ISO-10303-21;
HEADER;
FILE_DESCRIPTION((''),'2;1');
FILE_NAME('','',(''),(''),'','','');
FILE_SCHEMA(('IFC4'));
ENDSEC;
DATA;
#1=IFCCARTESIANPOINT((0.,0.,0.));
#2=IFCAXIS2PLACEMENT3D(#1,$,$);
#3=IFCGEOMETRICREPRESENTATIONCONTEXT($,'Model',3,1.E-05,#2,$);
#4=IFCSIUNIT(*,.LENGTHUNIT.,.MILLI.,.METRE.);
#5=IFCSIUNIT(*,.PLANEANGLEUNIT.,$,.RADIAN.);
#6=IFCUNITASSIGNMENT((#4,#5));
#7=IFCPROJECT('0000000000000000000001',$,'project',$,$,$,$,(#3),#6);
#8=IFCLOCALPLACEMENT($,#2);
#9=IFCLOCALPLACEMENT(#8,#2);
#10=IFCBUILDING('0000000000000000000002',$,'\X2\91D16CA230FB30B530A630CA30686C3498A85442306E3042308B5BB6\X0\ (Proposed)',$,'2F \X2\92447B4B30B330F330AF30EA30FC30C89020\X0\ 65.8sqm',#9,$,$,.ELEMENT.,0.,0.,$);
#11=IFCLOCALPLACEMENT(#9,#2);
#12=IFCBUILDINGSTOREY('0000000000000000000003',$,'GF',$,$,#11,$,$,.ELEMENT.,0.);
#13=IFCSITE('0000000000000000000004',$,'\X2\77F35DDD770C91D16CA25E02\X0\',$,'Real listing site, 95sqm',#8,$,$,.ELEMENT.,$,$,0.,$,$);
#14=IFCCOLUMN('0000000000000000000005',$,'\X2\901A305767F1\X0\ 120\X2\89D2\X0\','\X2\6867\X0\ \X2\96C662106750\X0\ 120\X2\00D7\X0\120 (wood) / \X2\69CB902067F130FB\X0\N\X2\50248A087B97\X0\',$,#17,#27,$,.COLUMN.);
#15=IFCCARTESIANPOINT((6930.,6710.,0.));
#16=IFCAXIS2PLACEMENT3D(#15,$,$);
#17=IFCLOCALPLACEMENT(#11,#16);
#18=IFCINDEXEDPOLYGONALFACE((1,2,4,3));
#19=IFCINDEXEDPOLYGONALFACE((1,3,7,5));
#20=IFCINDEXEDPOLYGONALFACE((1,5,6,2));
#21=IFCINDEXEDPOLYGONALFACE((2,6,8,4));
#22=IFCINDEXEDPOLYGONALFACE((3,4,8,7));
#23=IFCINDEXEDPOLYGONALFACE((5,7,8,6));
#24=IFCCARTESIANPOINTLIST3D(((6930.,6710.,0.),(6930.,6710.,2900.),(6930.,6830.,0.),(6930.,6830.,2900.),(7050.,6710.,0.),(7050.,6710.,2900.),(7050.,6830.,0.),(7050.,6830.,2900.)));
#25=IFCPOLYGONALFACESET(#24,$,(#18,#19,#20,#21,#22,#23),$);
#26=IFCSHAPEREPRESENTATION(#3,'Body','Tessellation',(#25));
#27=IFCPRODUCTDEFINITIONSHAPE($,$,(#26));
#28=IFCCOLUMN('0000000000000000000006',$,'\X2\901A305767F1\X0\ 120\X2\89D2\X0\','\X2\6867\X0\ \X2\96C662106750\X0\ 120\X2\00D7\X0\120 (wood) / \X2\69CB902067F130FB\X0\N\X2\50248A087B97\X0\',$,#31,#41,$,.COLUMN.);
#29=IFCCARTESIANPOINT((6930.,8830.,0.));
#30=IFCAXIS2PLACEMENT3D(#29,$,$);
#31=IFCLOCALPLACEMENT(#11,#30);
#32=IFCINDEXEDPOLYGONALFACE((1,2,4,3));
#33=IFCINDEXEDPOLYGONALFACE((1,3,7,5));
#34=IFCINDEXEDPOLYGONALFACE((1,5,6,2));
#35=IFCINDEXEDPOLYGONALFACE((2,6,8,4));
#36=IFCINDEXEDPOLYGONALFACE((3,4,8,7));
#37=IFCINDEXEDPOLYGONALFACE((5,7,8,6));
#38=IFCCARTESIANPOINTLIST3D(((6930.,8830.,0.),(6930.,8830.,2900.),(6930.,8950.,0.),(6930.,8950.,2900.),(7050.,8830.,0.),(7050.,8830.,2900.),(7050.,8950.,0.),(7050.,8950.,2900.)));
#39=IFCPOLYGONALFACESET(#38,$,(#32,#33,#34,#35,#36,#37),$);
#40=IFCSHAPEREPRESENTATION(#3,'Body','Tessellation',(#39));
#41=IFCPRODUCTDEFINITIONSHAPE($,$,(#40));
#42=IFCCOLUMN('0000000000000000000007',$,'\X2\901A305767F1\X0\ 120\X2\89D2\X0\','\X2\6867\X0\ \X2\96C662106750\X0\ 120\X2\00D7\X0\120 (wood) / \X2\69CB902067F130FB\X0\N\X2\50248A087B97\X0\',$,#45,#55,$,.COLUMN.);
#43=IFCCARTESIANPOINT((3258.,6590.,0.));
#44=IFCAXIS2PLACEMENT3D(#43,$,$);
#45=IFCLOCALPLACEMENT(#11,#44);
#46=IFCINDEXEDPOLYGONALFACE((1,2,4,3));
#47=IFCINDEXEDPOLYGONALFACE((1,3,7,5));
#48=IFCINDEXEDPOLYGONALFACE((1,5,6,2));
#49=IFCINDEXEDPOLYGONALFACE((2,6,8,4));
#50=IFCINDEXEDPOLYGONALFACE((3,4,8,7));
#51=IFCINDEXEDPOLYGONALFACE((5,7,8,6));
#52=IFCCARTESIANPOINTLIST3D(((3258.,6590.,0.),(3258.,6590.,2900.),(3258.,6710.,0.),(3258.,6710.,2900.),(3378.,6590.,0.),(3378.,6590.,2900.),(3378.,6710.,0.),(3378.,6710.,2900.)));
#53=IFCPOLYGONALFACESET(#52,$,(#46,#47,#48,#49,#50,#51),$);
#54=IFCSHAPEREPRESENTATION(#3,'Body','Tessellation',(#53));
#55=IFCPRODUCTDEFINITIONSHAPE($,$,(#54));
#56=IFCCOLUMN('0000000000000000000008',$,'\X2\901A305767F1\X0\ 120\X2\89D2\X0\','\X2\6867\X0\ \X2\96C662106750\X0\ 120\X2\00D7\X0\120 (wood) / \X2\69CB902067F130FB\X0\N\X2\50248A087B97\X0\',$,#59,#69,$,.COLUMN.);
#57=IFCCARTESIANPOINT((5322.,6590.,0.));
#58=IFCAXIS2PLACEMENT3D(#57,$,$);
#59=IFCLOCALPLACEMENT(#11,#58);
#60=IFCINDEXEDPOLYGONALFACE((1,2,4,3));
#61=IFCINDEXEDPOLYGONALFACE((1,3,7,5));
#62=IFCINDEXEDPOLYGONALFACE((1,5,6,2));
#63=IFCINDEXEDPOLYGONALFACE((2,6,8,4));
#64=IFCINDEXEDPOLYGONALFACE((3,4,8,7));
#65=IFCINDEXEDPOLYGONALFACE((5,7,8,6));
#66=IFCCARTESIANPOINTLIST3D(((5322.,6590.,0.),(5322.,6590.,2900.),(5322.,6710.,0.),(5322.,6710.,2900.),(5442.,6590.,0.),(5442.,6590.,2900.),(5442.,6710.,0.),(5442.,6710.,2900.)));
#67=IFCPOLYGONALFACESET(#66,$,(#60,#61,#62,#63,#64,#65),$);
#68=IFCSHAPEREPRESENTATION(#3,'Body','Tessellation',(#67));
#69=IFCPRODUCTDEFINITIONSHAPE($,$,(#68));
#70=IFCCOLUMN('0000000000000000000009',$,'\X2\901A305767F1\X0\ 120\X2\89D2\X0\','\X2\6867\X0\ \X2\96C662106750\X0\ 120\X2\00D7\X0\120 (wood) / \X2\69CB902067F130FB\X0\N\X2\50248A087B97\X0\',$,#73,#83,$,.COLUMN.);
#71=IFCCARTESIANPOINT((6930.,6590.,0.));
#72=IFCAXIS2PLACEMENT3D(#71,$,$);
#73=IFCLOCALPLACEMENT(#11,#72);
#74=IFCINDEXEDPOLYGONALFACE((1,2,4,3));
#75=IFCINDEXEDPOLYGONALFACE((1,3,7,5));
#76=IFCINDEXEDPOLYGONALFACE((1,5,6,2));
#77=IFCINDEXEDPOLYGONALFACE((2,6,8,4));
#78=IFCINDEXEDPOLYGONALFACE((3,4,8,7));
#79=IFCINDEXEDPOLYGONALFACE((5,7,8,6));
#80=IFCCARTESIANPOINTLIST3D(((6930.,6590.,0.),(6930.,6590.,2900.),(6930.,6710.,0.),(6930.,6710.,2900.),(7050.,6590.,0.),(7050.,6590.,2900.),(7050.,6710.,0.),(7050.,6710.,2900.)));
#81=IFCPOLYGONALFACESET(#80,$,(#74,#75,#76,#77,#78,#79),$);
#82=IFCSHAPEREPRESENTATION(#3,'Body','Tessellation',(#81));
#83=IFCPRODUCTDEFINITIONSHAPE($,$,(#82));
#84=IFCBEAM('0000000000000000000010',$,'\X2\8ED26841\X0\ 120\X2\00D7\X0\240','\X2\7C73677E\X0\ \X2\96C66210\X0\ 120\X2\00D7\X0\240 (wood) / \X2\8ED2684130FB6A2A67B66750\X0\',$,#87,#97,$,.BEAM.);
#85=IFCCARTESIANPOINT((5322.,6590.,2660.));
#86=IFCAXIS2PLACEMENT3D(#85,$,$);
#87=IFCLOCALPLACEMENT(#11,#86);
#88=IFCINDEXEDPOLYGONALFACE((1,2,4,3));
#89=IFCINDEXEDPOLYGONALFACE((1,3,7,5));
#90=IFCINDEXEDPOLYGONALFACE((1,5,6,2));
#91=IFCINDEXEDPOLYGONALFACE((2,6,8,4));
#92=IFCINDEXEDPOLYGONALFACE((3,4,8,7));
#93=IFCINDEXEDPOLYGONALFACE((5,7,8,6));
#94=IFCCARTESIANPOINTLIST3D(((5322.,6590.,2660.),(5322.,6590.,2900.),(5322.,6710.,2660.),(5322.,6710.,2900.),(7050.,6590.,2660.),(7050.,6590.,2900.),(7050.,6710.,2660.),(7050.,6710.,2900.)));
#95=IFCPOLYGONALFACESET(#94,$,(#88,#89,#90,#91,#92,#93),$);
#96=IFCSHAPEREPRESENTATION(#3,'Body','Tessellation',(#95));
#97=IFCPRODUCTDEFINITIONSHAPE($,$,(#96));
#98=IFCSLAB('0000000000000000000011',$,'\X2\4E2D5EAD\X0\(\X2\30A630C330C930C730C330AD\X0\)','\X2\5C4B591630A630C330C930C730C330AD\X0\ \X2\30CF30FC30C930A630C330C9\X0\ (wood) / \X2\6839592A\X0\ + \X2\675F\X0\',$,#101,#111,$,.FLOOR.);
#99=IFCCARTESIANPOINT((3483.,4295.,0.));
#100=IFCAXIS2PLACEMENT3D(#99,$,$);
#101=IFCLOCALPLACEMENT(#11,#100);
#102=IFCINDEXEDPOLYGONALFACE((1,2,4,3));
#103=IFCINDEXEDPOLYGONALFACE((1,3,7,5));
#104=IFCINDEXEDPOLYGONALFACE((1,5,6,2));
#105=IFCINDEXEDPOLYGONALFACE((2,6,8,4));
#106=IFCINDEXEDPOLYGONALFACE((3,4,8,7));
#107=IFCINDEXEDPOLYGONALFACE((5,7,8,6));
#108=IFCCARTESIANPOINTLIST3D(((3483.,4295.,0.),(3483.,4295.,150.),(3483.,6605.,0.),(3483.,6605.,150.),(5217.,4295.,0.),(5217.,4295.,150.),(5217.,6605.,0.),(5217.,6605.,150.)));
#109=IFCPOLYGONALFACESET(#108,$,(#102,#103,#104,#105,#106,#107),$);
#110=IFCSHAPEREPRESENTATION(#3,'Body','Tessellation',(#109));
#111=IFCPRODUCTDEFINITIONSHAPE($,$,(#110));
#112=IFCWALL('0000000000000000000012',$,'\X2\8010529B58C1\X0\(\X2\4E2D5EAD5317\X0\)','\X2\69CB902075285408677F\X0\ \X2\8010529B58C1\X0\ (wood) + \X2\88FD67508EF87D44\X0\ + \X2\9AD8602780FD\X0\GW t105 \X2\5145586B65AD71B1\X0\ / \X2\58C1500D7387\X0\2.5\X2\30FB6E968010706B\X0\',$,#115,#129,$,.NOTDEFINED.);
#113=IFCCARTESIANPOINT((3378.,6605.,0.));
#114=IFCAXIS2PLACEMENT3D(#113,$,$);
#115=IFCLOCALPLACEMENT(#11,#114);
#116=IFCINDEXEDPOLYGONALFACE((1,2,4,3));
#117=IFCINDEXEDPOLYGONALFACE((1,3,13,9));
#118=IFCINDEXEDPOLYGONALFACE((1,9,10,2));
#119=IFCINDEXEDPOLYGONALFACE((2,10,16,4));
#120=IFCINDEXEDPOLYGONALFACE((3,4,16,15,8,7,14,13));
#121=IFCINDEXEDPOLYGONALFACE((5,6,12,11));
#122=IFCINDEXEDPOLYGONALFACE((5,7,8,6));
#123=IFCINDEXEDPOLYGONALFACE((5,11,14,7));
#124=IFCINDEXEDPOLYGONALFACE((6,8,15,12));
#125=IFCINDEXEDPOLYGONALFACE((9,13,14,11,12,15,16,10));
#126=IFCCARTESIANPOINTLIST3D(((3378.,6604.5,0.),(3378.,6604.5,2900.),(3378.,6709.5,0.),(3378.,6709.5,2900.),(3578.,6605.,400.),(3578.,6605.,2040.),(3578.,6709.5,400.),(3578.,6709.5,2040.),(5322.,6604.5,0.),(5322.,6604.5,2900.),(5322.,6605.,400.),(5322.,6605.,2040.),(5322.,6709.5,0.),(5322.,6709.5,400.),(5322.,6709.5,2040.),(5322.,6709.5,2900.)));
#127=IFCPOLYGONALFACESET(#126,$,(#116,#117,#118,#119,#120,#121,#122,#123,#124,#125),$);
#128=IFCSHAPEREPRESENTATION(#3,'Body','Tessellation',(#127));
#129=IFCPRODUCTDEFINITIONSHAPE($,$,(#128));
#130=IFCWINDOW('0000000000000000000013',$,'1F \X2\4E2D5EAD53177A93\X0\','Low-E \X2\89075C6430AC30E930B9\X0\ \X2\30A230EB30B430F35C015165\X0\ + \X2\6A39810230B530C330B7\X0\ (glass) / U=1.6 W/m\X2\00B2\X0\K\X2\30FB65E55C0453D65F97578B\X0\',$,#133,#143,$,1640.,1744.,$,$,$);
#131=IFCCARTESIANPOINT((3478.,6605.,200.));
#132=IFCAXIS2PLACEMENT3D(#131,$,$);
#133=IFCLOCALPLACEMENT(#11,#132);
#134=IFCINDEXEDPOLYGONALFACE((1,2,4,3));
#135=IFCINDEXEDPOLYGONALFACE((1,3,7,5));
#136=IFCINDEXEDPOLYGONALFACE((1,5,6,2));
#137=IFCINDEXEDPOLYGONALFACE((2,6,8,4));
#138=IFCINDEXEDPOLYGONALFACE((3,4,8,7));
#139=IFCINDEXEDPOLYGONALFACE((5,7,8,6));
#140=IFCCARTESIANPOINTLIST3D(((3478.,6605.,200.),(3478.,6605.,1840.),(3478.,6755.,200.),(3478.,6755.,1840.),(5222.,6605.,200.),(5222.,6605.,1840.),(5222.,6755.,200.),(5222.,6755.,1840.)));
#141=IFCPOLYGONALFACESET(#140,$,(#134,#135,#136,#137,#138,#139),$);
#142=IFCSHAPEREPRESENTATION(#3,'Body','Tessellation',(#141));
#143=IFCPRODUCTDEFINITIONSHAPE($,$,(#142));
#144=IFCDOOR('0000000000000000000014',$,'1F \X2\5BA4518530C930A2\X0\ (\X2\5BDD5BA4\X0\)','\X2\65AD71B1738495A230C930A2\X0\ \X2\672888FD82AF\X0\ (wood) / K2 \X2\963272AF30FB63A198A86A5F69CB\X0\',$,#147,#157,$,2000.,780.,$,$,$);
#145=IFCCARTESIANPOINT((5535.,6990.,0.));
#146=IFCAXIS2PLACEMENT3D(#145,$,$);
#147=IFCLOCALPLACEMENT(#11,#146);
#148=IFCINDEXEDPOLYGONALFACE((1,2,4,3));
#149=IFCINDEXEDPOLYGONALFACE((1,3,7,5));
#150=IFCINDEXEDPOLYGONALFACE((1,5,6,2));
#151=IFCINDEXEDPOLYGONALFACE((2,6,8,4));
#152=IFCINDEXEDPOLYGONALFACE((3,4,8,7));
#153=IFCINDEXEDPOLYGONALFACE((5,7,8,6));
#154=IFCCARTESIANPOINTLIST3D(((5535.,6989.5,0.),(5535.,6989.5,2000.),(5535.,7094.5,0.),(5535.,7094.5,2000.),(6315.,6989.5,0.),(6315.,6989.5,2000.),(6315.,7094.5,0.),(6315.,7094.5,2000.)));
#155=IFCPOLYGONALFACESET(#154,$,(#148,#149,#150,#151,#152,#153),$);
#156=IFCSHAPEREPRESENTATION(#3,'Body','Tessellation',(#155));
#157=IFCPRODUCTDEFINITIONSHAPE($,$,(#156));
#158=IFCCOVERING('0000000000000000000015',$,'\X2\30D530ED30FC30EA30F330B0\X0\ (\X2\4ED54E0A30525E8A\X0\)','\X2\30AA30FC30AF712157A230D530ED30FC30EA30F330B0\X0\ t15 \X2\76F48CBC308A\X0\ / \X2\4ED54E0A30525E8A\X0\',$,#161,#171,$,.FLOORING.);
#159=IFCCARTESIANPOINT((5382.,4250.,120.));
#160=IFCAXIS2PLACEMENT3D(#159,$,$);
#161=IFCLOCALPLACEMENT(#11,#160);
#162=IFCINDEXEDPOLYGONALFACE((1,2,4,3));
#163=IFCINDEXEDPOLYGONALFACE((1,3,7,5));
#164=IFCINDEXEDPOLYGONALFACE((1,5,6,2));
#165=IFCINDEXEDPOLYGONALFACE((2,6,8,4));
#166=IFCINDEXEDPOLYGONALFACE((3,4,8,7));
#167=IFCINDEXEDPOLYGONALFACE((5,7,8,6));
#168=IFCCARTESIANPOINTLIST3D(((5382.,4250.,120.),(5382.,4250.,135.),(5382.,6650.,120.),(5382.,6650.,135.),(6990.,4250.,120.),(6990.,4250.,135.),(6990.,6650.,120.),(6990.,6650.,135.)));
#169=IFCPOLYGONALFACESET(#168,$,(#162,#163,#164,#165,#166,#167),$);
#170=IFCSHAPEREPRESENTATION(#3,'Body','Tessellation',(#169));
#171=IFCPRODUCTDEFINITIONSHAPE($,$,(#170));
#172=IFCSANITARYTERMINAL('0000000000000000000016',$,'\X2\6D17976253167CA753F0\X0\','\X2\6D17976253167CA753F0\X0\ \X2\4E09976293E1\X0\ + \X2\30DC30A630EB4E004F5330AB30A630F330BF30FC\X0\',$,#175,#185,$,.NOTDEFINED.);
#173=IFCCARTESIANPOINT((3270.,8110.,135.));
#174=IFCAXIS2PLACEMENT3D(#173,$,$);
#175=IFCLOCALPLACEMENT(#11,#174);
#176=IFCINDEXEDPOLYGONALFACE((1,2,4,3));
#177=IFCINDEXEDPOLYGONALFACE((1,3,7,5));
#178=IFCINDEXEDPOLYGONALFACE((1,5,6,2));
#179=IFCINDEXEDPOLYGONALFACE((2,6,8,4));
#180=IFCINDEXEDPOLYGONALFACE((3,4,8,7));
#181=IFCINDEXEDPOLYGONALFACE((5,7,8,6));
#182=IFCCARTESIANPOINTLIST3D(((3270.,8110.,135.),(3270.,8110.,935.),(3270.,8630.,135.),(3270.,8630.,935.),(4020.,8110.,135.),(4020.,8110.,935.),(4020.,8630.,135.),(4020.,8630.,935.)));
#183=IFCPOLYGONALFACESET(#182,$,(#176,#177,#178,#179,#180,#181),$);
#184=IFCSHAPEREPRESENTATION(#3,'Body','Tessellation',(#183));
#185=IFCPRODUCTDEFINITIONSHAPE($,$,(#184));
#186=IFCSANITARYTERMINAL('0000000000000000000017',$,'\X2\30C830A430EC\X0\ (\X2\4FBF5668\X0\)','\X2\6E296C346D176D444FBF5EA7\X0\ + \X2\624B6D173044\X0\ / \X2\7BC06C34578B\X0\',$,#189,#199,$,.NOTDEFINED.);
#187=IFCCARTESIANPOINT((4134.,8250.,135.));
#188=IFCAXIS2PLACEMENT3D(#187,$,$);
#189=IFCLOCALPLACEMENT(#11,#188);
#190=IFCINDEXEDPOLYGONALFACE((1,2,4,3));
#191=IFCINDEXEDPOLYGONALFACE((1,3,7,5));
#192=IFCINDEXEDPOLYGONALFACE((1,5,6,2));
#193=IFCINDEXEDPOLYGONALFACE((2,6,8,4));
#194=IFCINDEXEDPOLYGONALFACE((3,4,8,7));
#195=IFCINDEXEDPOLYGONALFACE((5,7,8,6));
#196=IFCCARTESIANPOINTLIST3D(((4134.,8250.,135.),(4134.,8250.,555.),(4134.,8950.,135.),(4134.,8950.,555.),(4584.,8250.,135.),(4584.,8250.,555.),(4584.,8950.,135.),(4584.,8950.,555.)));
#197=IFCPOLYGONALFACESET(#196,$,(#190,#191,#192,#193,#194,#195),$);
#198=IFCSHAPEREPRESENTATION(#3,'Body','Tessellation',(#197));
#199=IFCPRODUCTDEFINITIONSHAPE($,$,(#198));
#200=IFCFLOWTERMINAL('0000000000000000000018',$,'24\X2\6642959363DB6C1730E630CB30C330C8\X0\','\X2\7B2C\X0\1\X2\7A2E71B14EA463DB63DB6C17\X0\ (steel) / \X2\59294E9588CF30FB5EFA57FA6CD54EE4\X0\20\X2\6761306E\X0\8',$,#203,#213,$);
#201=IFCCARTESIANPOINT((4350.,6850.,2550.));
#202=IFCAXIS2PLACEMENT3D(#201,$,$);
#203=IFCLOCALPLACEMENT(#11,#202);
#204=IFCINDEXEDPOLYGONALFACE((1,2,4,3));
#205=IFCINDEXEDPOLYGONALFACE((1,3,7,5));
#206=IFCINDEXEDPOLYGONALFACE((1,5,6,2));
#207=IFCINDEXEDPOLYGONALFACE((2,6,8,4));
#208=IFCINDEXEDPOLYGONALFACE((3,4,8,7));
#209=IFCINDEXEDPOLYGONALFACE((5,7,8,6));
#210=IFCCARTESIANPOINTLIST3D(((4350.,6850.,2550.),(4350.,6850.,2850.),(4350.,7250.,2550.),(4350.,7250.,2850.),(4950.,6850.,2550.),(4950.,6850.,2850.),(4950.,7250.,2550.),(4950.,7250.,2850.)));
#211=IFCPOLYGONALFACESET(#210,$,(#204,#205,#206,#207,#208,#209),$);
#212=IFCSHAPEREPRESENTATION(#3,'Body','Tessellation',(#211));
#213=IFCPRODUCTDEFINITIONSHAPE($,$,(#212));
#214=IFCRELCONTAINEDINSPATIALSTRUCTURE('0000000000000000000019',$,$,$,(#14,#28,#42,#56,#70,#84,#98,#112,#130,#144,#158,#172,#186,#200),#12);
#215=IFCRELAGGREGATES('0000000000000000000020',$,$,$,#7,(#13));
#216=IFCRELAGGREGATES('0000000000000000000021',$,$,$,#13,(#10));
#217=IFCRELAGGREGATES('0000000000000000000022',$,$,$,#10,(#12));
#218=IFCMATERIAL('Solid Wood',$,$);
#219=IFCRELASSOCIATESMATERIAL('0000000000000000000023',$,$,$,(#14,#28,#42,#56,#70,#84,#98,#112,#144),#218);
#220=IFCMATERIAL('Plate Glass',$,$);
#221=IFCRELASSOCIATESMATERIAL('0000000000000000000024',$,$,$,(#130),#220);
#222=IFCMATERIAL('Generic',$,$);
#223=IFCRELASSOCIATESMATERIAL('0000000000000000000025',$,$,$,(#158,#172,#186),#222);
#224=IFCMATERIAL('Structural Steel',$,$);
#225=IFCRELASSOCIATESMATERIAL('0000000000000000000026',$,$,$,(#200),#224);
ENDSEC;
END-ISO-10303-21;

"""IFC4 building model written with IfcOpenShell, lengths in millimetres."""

from ifc_helpers import new_model, si_unit, frame, frame_2d, origin, place, context, project, spatial, rectangle, extrude, material, element, fill, save


model = new_model("IFC4")

# Units and contexts
model_context = context("Model", 3, precision=1e-05, world=origin())
ifc_project = project(units=[si_unit("LENGTHUNIT", "METRE", prefix="MILLI"), si_unit("PLANEANGLEUNIT", "RADIAN")], contexts=[model_context])

# Site, building, storey
site_placement = place(None, origin())
site = spatial("IfcSite", under=ifc_project, at=site_placement, Name="石川県金沢市", ObjectType="Real listing site, 95sqm", CompositionType="ELEMENT", RefElevation=0.0)
building_placement = place(site_placement, origin())
building = spatial("IfcBuilding", under=site, at=building_placement, Name="金沢・サウナと水風呂のある家 (Proposed)", ObjectType="2F 鉄筋コンクリート造 65.8sqm", CompositionType="ELEMENT", ElevationOfRefHeight=0.0, ElevationOfTerrain=0.0)
storey_placement = place(building_placement, origin())
storey = spatial("IfcBuildingStorey", under=building, at=storey_placement, Name="GF", CompositionType="ELEMENT", Elevation=0.0)

# Columns
ifc_material_1 = material(Name="Solid Wood")
column_1_placement = place(storey_placement, frame((6930.0, 6710.0, 0.0)))
element("IfcColumn", 1, at=column_1_placement, inside=storey, material=ifc_material_1, Name="通し柱 120角", Description="桧 集成材 120×120 (wood) / 構造柱・N値計算", PredefinedType="COLUMN", context=model_context, shape_type="SweptSolid", body=[
    extrude(rectangle(XDim=120.0, YDim=120.0, at=frame_2d((60.0, 60.0))), frame((6930.0, 6710.0, 0.0)), (0.0, 0.0, 1.0), 2900.0),
])
column_2_placement = place(storey_placement, frame((6930.0, 8830.0, 0.0)))
element("IfcColumn", 2, at=column_2_placement, inside=storey, material=ifc_material_1, Name="通し柱 120角", Description="桧 集成材 120×120 (wood) / 構造柱・N値計算", PredefinedType="COLUMN", context=model_context, shape_type="SweptSolid", body=[
    extrude(rectangle(XDim=120.0, YDim=120.0, at=frame_2d((60.0, 60.0))), frame((6930.0, 8830.0, 0.0)), (0.0, 0.0, 1.0), 2900.0),
])
column_3_placement = place(storey_placement, frame((3258.0, 6590.0, 0.0)))
element("IfcColumn", 3, at=column_3_placement, inside=storey, material=ifc_material_1, Name="通し柱 120角", Description="桧 集成材 120×120 (wood) / 構造柱・N値計算", PredefinedType="COLUMN", context=model_context, shape_type="SweptSolid", body=[
    extrude(rectangle(XDim=120.0, YDim=120.0, at=frame_2d((60.0, 60.0))), frame((3258.0, 6590.0, 0.0)), (0.0, 0.0, 1.0), 2900.0),
])
column_4_placement = place(storey_placement, frame((5322.0, 6590.0, 0.0)))
element("IfcColumn", 4, at=column_4_placement, inside=storey, material=ifc_material_1, Name="通し柱 120角", Description="桧 集成材 120×120 (wood) / 構造柱・N値計算", PredefinedType="COLUMN", context=model_context, shape_type="SweptSolid", body=[
    extrude(rectangle(XDim=120.0, YDim=120.0, at=frame_2d((60.0, 60.0))), frame((5322.0, 6590.0, 0.0)), (0.0, 0.0, 1.0), 2900.0),
])
column_5_placement = place(storey_placement, frame((6930.0, 6590.0, 0.0)))
element("IfcColumn", 5, at=column_5_placement, inside=storey, material=ifc_material_1, Name="通し柱 120角", Description="桧 集成材 120×120 (wood) / 構造柱・N値計算", PredefinedType="COLUMN", context=model_context, shape_type="SweptSolid", body=[
    extrude(rectangle(XDim=120.0, YDim=120.0, at=frame_2d((60.0, 60.0))), frame((6930.0, 6590.0, 0.0)), (0.0, 0.0, 1.0), 2900.0),
])

# Beam
beam_1_placement = place(storey_placement, frame((5322.0, 6590.0, 2660.0)))
element("IfcBeam", 6, at=beam_1_placement, inside=storey, material=ifc_material_1, Name="軒桁 120×240", Description="米松 集成 120×240 (wood) / 軒桁・横架材", PredefinedType="BEAM", context=model_context, shape_type="SweptSolid", body=[
    extrude(rectangle(XDim=1728.0, YDim=120.0, at=frame_2d((864.0, 60.0))), frame((5322.0, 6590.0, 2660.0)), (0.0, 0.0, 1.0), 240.0),
])

# Slab
slab_placement = place(storey_placement, frame((3483.0, 4295.0, 0.0)))
element("IfcSlab", 7, at=slab_placement, inside=storey, material=ifc_material_1, Name="中庭(ウッドデッキ)", Description="屋外ウッドデッキ ハードウッド (wood) / 根太 + 束", PredefinedType="FLOOR", context=model_context, shape_type="SweptSolid", body=[
    extrude(rectangle(XDim=1734.0, YDim=2310.0, at=frame_2d((867.0, 1155.0))), frame((3483.0, 4295.0, 0.0)), (0.0, 0.0, 1.0), 150.0),
])

# Wall, opening, window
wall_1_placement = place(storey_placement, frame((3378.0, 6605.0, 0.0)))
wall_1 = element("IfcWall", 8, at=wall_1_placement, inside=storey, material=ifc_material_1, Name="耐力壁(中庭北)", Description="構造用合板 耐力壁 (wood) + 製材軸組 + 高性能GW t105 充填断熱 / 壁倍率2.5・準耐火", PredefinedType="NOTDEFINED", context=model_context, shape_type="SweptSolid", body=[
    extrude(rectangle(XDim=1944.0, YDim=105.0, at=frame_2d((972.0, 52.0))), frame((3378.0, 6605.0, 0.0)), (0.0, 0.0, 1.0), 2900.0),
])
opening_placement = place(storey_placement, frame((3478.0, 6605.0, 200.0)))
opening = element("IfcOpeningElement", 9, at=opening_placement, cuts=wall_1, PredefinedType="NOTDEFINED", context=model_context, shape_type="SweptSolid", body=[
    extrude(rectangle(XDim=1744.0, YDim=150.0, at=frame_2d((872.0, 75.0))), frame((3478.0, 6605.0, 200.0)), (0.0, 0.0, 1.0), 1640.0),
])
ifc_material_2 = material(Name="Plate Glass")
window_placement = place(storey_placement, frame((3478.0, 6605.0, 200.0)))
window = element("IfcWindow", 10, at=window_placement, inside=storey, material=ifc_material_2, Name="1F 中庭北窓", Description="Low-E 複層ガラス アルゴン封入 + 樹脂サッシ (glass) / U=1.6 W/m²K・日射取得型", OverallHeight=1640.0, OverallWidth=1744.0, context=model_context, shape_type="SweptSolid", body=[
    extrude(rectangle(XDim=1744.0, YDim=150.0, at=frame_2d((872.0, 75.0))), frame((3478.0, 6605.0, 200.0)), (0.0, 0.0, 1.0), 1640.0),
])
fill(opening, window)

# Door
door_placement = place(storey_placement, frame((5535.0, 6990.0, 0.0)))
element("IfcDoor", 11, at=door_placement, inside=storey, material=ifc_material_1, Name="1F 室内ドア (寝室)", Description="断熱玄関ドア 木製芯 (wood) / K2 防犯・採風機構", OverallHeight=2000.0, OverallWidth=780.0, context=model_context, shape_type="SweptSolid", body=[
    extrude(rectangle(XDim=780.0, YDim=105.0, at=frame_2d((390.0, 52.0))), frame((5535.0, 6990.0, 0.0)), (0.0, 0.0, 1.0), 2000.0),
])

# Covering
ifc_material_3 = material(Name="Generic")
covering_placement = place(storey_placement, frame((5382.0, 4250.0, 120.0)))
element("IfcCovering", 12, at=covering_placement, inside=storey, material=ifc_material_3, Name="フローリング (仕上げ床)", Description="オーク無垢フローリング t15 直貼り / 仕上げ床", PredefinedType="FLOORING", context=model_context, shape_type="SweptSolid", body=[
    extrude(rectangle(XDim=1608.0, YDim=2400.0, at=frame_2d((804.0, 1200.0))), frame((5382.0, 4250.0, 120.0)), (0.0, 0.0, 1.0), 15.0),
])

# Sanitary terminals
sanitary_terminal_1_placement = place(storey_placement, frame((3270.0, 8110.0, 135.0)))
element("IfcSanitaryTerminal", 13, at=sanitary_terminal_1_placement, inside=storey, material=ifc_material_3, Name="洗面化粧台", Description="洗面化粧台 三面鏡 + ボウル一体カウンター", PredefinedType="NOTDEFINED", context=model_context, shape_type="SweptSolid", body=[
    extrude(rectangle(XDim=750.0, YDim=520.0, at=frame_2d((375.0, 260.0))), frame((3270.0, 8110.0, 135.0)), (0.0, 0.0, 1.0), 800.0),
])
sanitary_terminal_2_placement = place(storey_placement, frame((4134.0, 8250.0, 135.0)))
element("IfcSanitaryTerminal", 14, at=sanitary_terminal_2_placement, inside=storey, material=ifc_material_3, Name="トイレ (便器)", Description="温水洗浄便座 + 手洗い / 節水型", PredefinedType="NOTDEFINED", context=model_context, shape_type="SweptSolid", body=[
    extrude(rectangle(XDim=450.0, YDim=700.0, at=frame_2d((225.0, 350.0))), frame((4134.0, 8250.0, 135.0)), (0.0, 0.0, 1.0), 420.0),
])

# Flow terminal
ifc_material_4 = material(Name="Structural Steel")
flow_terminal_placement = place(storey_placement, frame((4350.0, 6850.0, 2550.0)))
element("IfcFlowTerminal", 15, at=flow_terminal_placement, inside=storey, material=ifc_material_4, Name="24時間換気ユニット", Description="第1種熱交換換気 (steel) / 天井裏・建基法令20条の8", context=model_context, shape_type="SweptSolid", body=[
    extrude(rectangle(XDim=600.0, YDim=400.0, at=frame_2d((300.0, 200.0))), frame((4350.0, 6850.0, 2550.0)), (0.0, 0.0, 1.0), 300.0),
])

save(model, "model.ifc")
